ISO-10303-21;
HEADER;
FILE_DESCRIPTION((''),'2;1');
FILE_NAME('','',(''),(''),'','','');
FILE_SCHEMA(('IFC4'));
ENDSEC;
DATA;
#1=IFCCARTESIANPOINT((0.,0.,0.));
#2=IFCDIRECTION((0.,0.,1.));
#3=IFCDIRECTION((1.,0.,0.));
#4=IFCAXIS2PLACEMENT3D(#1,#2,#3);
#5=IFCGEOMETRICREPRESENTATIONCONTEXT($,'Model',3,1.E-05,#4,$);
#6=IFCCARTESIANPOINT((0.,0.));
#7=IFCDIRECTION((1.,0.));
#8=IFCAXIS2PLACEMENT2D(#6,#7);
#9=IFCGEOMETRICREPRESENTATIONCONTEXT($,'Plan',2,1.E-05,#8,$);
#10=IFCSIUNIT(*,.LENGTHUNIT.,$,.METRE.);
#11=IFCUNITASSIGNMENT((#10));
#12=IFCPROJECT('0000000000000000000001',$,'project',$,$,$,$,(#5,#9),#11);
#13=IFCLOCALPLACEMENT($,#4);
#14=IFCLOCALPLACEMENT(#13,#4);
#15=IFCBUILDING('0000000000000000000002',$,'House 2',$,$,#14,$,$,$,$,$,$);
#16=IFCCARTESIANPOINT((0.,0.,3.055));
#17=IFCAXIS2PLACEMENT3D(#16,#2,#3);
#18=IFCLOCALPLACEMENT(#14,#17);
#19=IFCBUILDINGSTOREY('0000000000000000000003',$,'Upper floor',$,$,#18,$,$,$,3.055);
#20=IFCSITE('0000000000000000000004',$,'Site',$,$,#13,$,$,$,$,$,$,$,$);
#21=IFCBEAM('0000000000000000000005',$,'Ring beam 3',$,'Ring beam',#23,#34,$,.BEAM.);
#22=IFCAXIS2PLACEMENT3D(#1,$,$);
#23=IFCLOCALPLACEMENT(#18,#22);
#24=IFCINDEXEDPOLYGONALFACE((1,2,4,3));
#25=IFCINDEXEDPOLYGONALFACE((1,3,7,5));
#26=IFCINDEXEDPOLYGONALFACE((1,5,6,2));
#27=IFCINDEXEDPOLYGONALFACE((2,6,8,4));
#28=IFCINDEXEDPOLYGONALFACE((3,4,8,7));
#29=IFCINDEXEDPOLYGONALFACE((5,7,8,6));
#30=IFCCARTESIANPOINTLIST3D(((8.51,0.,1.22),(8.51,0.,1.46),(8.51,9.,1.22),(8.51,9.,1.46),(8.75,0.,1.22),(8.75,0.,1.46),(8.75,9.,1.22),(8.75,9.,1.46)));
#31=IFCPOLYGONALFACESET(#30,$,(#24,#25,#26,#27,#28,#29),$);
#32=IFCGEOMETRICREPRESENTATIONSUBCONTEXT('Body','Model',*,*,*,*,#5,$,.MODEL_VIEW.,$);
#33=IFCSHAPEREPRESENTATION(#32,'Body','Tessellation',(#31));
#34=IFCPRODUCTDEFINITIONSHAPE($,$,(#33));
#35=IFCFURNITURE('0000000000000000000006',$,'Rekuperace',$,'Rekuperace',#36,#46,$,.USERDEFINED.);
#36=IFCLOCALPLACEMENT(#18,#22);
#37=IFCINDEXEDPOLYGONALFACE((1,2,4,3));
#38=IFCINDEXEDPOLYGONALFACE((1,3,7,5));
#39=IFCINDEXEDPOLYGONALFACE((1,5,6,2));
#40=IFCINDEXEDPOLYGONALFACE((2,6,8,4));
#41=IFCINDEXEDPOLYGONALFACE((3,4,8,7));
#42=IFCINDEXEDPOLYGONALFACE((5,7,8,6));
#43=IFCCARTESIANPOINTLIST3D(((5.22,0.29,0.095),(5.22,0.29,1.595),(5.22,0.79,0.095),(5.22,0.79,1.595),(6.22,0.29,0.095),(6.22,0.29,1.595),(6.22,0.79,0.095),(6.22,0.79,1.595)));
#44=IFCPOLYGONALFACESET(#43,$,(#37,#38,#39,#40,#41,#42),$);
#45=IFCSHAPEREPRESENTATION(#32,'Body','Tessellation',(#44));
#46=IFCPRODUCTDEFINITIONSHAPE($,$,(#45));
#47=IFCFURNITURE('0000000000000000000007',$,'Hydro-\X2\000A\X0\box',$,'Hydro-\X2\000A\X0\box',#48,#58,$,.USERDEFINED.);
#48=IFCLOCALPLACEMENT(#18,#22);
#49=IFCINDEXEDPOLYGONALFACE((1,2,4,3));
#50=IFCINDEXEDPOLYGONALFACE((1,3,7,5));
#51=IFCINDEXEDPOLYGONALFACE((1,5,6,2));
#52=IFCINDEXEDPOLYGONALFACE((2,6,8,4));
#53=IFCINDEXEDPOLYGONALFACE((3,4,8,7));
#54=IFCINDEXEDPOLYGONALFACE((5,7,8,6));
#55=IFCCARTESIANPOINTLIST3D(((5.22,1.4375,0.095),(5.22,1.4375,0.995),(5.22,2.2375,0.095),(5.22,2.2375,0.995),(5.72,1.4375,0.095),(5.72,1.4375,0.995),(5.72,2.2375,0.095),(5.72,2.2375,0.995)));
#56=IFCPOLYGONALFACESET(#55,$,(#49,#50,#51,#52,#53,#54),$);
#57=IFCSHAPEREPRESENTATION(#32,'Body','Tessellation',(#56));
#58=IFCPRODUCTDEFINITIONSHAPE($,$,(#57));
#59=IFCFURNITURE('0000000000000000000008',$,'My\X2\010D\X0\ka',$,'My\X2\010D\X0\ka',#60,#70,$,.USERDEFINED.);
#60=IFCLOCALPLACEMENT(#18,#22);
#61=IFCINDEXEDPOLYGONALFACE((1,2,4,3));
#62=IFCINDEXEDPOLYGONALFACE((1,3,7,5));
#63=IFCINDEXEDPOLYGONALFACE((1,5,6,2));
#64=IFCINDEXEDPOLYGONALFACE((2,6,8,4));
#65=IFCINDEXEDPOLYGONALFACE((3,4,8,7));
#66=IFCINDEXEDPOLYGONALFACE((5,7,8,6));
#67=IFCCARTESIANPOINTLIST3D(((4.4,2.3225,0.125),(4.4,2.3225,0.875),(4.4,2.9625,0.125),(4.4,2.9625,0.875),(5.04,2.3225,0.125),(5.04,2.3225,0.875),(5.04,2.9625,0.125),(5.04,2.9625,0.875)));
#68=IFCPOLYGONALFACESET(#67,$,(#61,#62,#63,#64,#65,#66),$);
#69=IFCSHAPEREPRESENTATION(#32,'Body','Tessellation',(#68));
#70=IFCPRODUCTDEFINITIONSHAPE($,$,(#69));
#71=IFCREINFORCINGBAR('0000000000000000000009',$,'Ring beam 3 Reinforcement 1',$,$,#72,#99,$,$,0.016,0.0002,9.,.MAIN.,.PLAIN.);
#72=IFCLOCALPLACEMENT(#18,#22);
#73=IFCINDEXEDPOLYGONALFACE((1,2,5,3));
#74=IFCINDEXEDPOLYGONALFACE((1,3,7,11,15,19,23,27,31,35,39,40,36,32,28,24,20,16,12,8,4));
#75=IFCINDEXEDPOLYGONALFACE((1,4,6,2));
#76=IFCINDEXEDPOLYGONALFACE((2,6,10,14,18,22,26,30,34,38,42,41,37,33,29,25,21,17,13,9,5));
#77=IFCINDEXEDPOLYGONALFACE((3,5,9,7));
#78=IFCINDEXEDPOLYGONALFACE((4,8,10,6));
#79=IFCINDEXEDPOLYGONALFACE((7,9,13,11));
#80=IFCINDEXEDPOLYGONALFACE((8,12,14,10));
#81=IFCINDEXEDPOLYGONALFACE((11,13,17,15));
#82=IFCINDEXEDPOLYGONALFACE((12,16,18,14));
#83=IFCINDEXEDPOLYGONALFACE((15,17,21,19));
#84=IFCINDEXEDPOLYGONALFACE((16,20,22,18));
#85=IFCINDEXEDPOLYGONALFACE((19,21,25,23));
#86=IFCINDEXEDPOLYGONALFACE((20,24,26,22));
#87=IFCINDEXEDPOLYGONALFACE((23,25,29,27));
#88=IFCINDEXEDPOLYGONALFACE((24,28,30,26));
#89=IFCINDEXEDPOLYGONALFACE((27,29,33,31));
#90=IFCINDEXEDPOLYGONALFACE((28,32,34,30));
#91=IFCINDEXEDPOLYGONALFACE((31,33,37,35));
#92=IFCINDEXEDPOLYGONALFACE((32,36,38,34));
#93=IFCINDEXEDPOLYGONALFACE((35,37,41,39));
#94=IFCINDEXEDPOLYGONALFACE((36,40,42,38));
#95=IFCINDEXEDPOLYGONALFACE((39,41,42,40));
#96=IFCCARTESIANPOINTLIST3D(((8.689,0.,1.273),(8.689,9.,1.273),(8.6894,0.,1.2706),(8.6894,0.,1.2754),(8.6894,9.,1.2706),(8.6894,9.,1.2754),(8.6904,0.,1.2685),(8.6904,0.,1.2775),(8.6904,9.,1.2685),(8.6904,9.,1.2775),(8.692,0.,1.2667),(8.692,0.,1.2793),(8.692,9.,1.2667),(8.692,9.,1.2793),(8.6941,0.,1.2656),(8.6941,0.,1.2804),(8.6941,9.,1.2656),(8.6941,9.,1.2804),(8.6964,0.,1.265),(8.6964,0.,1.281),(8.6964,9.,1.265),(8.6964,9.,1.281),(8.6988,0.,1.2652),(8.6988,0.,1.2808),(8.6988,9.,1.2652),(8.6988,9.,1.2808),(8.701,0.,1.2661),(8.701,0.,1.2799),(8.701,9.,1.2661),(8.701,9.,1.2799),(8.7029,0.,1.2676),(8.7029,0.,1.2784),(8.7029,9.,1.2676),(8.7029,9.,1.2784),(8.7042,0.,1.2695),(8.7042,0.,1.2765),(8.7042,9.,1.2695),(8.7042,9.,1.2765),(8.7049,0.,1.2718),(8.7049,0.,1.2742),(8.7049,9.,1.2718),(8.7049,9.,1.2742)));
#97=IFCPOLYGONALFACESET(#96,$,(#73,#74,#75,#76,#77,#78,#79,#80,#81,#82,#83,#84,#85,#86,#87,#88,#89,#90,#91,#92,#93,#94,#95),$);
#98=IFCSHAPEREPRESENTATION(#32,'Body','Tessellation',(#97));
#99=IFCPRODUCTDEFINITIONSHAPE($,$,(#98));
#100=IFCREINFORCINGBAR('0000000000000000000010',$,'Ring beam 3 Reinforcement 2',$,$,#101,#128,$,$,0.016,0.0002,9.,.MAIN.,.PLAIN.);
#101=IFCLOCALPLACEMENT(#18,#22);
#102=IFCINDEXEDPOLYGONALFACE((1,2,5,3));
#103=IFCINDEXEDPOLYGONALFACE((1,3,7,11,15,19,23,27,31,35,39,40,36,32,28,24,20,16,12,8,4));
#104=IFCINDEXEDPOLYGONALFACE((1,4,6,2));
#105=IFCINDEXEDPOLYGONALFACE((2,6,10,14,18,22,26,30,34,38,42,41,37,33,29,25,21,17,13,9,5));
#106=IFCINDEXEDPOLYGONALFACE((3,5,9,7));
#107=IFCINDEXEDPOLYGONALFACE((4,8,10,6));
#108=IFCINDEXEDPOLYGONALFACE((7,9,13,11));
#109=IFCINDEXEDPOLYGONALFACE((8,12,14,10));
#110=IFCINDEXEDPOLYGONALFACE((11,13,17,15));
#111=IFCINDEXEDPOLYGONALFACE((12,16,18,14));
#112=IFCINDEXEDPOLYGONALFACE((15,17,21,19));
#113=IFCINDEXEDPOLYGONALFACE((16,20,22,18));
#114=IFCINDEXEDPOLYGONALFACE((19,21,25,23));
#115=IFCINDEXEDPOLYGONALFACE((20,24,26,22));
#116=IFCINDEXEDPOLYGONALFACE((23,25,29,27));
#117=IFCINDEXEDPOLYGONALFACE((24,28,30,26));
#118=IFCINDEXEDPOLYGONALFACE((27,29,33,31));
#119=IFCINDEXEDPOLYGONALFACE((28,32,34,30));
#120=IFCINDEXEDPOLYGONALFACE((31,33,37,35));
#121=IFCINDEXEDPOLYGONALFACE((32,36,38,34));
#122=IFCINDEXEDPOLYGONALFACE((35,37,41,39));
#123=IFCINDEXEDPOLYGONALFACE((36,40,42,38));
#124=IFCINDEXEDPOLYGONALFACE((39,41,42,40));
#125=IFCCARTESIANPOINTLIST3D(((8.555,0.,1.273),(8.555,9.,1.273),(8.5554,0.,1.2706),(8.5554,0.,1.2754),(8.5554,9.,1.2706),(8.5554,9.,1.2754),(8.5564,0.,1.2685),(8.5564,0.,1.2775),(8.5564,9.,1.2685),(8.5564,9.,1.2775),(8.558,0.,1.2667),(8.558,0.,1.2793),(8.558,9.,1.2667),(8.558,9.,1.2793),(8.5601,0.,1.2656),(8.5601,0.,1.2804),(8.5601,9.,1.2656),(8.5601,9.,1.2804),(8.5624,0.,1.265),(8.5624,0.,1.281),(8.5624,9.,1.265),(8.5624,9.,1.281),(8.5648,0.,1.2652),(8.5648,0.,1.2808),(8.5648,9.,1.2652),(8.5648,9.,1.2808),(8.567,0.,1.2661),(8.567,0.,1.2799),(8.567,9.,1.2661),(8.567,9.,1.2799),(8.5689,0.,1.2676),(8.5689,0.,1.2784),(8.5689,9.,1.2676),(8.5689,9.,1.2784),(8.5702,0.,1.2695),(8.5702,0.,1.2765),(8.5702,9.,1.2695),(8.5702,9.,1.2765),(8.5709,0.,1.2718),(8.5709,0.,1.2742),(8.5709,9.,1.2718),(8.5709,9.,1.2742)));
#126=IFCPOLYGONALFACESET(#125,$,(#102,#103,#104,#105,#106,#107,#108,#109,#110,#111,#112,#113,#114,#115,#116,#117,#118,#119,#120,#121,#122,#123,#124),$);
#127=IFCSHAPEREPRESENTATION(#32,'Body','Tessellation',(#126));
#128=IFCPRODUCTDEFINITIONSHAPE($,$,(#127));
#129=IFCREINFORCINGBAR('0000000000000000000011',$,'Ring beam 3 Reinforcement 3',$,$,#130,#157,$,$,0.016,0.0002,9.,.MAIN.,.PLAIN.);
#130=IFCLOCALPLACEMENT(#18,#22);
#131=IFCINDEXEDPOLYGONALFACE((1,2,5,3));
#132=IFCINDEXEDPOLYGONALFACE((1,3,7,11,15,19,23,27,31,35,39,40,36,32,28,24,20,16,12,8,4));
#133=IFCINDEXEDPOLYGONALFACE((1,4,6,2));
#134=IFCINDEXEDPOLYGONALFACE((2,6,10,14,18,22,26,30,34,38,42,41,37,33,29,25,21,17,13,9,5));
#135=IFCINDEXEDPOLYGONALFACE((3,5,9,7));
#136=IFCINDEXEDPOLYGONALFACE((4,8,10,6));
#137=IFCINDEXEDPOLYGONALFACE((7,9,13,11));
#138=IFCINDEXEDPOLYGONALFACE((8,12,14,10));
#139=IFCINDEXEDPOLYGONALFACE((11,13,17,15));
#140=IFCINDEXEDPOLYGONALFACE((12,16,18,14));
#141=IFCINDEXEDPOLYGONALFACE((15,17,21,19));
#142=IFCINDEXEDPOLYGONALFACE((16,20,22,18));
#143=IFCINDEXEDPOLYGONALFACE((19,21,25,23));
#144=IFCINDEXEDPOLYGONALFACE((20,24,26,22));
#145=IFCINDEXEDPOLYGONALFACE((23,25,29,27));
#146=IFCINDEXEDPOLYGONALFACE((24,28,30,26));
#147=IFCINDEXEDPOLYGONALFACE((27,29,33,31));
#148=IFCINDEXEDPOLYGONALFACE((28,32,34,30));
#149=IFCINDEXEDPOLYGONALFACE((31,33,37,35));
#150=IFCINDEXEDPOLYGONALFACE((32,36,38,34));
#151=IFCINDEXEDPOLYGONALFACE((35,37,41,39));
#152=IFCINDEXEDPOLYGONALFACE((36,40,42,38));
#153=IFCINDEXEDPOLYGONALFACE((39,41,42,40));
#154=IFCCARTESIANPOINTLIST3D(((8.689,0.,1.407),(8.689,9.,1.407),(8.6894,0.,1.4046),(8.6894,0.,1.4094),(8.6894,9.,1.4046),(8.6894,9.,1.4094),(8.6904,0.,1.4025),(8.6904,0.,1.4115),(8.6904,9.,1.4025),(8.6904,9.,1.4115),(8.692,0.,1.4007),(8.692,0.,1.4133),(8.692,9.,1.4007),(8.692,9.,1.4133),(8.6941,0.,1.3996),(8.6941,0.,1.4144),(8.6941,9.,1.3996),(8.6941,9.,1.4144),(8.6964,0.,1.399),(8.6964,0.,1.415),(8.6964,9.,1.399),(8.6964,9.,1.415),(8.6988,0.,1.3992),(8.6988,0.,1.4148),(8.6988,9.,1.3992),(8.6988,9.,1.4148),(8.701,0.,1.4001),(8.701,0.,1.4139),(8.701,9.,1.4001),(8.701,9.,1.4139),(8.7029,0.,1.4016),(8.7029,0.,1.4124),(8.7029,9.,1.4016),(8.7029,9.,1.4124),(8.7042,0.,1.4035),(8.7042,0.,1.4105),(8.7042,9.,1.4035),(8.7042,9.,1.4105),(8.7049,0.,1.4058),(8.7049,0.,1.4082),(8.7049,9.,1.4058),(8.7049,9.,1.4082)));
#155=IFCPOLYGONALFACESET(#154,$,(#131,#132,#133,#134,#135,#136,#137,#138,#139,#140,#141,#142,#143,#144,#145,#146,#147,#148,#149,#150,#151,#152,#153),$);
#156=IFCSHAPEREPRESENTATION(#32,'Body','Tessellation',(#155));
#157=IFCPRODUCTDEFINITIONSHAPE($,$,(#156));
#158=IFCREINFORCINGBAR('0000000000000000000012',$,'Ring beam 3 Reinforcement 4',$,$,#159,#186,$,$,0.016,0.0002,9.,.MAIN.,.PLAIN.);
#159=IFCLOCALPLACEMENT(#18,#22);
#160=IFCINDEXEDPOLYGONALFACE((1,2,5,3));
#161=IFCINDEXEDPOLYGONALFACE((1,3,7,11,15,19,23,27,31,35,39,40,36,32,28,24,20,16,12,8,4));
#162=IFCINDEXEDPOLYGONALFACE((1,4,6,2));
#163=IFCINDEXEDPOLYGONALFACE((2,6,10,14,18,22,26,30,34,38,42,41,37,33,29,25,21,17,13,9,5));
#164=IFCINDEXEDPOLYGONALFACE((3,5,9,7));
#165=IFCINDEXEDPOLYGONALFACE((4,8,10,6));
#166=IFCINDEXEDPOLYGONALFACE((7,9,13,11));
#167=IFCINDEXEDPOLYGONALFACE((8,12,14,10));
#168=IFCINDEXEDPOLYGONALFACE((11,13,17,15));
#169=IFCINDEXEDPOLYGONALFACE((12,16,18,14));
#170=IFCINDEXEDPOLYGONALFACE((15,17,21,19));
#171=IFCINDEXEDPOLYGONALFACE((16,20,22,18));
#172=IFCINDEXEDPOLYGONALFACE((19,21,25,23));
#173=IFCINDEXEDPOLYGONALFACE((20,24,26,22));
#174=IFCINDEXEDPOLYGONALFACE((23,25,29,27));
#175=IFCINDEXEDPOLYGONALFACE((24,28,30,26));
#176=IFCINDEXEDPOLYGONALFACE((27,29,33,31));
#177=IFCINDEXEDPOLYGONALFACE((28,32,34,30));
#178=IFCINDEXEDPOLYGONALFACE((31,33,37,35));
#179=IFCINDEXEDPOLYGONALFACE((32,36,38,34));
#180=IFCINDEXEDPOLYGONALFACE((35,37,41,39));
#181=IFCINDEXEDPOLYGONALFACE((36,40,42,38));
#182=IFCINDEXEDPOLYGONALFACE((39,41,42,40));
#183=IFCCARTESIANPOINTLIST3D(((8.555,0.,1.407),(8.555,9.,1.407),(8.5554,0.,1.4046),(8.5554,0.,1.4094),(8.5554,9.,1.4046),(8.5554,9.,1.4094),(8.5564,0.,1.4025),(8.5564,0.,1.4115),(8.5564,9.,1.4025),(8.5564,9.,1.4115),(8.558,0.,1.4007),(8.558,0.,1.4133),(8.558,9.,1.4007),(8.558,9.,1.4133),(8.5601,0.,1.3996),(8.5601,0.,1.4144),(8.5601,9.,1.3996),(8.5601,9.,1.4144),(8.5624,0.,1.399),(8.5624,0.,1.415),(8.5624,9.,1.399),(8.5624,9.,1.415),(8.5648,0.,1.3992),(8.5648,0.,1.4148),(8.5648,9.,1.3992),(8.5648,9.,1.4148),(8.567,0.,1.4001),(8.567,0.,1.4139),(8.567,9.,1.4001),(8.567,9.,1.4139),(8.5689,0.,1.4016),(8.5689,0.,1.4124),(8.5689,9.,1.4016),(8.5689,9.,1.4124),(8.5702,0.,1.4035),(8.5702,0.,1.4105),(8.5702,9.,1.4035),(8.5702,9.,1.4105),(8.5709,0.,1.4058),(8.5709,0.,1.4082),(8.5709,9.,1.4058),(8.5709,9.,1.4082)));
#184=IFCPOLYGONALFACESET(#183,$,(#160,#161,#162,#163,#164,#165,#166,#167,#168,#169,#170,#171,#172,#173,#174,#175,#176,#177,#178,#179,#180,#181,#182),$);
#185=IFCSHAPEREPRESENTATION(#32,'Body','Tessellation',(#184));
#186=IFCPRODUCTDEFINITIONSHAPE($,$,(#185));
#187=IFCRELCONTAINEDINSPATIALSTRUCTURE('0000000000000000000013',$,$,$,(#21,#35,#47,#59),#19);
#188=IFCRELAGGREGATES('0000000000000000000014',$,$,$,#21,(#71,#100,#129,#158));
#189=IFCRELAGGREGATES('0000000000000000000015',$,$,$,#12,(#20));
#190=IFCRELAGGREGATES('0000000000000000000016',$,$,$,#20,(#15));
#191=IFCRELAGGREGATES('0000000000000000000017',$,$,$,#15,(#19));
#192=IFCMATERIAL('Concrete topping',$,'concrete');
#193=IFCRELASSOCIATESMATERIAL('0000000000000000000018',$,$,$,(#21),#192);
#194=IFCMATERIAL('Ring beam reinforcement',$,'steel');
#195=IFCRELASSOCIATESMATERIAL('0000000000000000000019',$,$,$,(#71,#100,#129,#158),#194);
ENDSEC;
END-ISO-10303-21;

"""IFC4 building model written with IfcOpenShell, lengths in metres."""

from ifc_helpers import new_model, entity, si_unit, frame, origin_with_axes, origin_2d, origin_2d_with_axis, place, context, subcontext, project, spatial, indexed_curve, circle_curve, rectangle, outline, extrude, shape, material, element, aggregate, save


model = new_model("IFC4")

# Units and contexts
model_context = context("Model", 3, precision=1e-05, world=origin_with_axes())
plan_context = context("Plan", 2, precision=1e-05, world=origin_2d_with_axis())
body_context_1 = subcontext(model_context, "Body", "Model", "MODEL_VIEW")
body_context_2 = subcontext(plan_context, "Body", "Plan", "PLAN_VIEW")
ifc_project = project(units=[si_unit("LENGTHUNIT", "METRE")], contexts=[model_context, plan_context])

# Site, building, storey
site_placement = place(None, origin_with_axes())
site = spatial("IfcSite", under=ifc_project, at=site_placement, Name="Site")
building_placement = place(site_placement, origin_with_axes())
building = spatial("IfcBuilding", under=site, at=building_placement, Name="House 2")
storey_placement = place(building_placement, frame((0.0, 0.0, 3.055), z_axis=(0.0, 0.0, 1.0), x_axis=(1.0, 0.0, 0.0)))
storey = spatial("IfcBuildingStorey", under=building, at=storey_placement, Name="Upper floor", Elevation=3.055)

# Beam
ifc_material_1 = material(Name="Concrete topping", Category="concrete")
beam_1_placement = place(storey_placement, frame((8.63, 0.0, 1.34), z_axis=(0.0, 0.0, 1.0), x_axis=(0.0, 1.0, 0.0)))
beam_1 = element("IfcBeam", 1, at=beam_1_placement, inside=storey, material=ifc_material_1, Name="Ring beam 3", ObjectType="Ring beam", PredefinedType="BEAM", context=body_context_1, shape_type="SweptSolid", body=[
    extrude(rectangle(XDim=0.24, YDim=0.24), frame((0.0, 0.0, 0.0), z_axis=(1.0, 0.0, 0.0), x_axis=(0.0, 1.0, 0.0)), (0.0, 0.0, 1.0), 9.0),
])

# Furniture
furniture_1_placement = place(storey_placement, frame((5.72, 0.54, 0.095), z_axis=(0.0, 0.0, 1.0), x_axis=(1.0, 0.0, 0.0)))
element("IfcFurniture", 2, at=furniture_1_placement, inside=storey, Name="Rekuperace", ObjectType="Rekuperace", PredefinedType="USERDEFINED", shapes=[
    shape(body_context_1, "Body", "SweptSolid", [extrude(outline(indexed_curve([(-0.5, -0.25), (0.5, -0.25), (0.5, 0.25), (-0.5, 0.25)])), None, (0.0, 0.0, 1.0), 1.5)]),
    shape(body_context_2, "Body", "Curve2D", [entity("IfcIndexedPolyCurve", entity("IfcCartesianPointList2D", [[-0.5, -0.25], [0.5, -0.25], [0.5, 0.25], [-0.5, 0.25], [-0.5, -0.25]]), None, False)]),
])
furniture_2_placement = place(storey_placement, frame((5.47, 1.8375, 0.095), z_axis=(0.0, 0.0, 1.0), x_axis=(0.0, 1.0, 0.0)))
element("IfcFurniture", 3, at=furniture_2_placement, inside=storey, Name="Hydro-\nbox", ObjectType="Hydro-\nbox", PredefinedType="USERDEFINED", shapes=[
    shape(body_context_1, "Body", "SweptSolid", [extrude(outline(indexed_curve([(-0.4, -0.25), (0.4, -0.25), (0.4, 0.25), (-0.4, 0.25)])), None, (0.0, 0.0, 1.0), 0.9)]),
    shape(body_context_2, "Body", "Curve2D", [entity("IfcIndexedPolyCurve", entity("IfcCartesianPointList2D", [[-0.4, -0.25], [0.4, -0.25], [0.4, 0.25], [-0.4, 0.25], [-0.4, -0.25]]), None, False)]),
])
furniture_3_placement = place(storey_placement, frame((4.72, 2.6425, 0.125), z_axis=(0.0, 0.0, 1.0), x_axis=(1.0, 0.0, 0.0)))
element("IfcFurniture", 4, at=furniture_3_placement, inside=storey, Name="Myčka", ObjectType="Myčka", PredefinedType="USERDEFINED", shapes=[
    shape(body_context_1, "Body", "SweptSolid", [extrude(outline(indexed_curve([(-0.32, -0.32), (0.32, -0.32), (0.32, 0.32), (-0.32, 0.32)])), None, (0.0, 0.0, 1.0), 0.75)]),
    shape(body_context_2, "Body", "Curve2D", [entity("IfcIndexedPolyCurve", entity("IfcCartesianPointList2D", [[-0.32, -0.32], [0.32, -0.32], [0.32, 0.32], [-0.32, 0.32], [-0.32, -0.32]]), None, False)]),
])

# Reinforcing bars
ifc_material_2 = material(Name="Ring beam reinforcement", Category="steel")
reinforcing_bar_1_placement = place(beam_1_placement, frame((0.0, -0.067, -0.067), z_axis=(0.0, 0.0, 1.0), x_axis=(1.0, 0.0, 0.0)))
reinforcing_bar_1 = element("IfcReinforcingBar", 5, at=reinforcing_bar_1_placement, material=ifc_material_2, Name="Ring beam 3 Reinforcement 1", BarLength=9.0, BarSurface="PLAIN", CrossSectionArea=0.0002, NominalDiameter=0.016, PredefinedType="MAIN", context=body_context_1, shape_type="SweptSolid", body=[
    extrude(outline(circle_curve(origin_2d(), 0.008)), frame((0.0, 0.0, 0.0), z_axis=(1.0, 0.0, 0.0), x_axis=(0.0, 1.0, 0.0)), (0.0, 0.0, 1.0), 9.0),
])
reinforcing_bar_2_placement = place(beam_1_placement, frame((0.0, 0.067, -0.067), z_axis=(0.0, 0.0, 1.0), x_axis=(1.0, 0.0, 0.0)))
reinforcing_bar_2 = element("IfcReinforcingBar", 6, at=reinforcing_bar_2_placement, material=ifc_material_2, Name="Ring beam 3 Reinforcement 2", BarLength=9.0, BarSurface="PLAIN", CrossSectionArea=0.0002, NominalDiameter=0.016, PredefinedType="MAIN", context=body_context_1, shape_type="SweptSolid", body=[
    extrude(outline(circle_curve(origin_2d(), 0.008)), frame((0.0, 0.0, 0.0), z_axis=(1.0, 0.0, 0.0), x_axis=(0.0, 1.0, 0.0)), (0.0, 0.0, 1.0), 9.0),
])
reinforcing_bar_3_placement = place(beam_1_placement, frame((0.0, -0.067, 0.067), z_axis=(0.0, 0.0, 1.0), x_axis=(1.0, 0.0, 0.0)))
reinforcing_bar_3 = element("IfcReinforcingBar", 7, at=reinforcing_bar_3_placement, material=ifc_material_2, Name="Ring beam 3 Reinforcement 3", BarLength=9.0, BarSurface="PLAIN", CrossSectionArea=0.0002, NominalDiameter=0.016, PredefinedType="MAIN", context=body_context_1, shape_type="SweptSolid", body=[
    extrude(outline(circle_curve(origin_2d(), 0.008)), frame((0.0, 0.0, 0.0), z_axis=(1.0, 0.0, 0.0), x_axis=(0.0, 1.0, 0.0)), (0.0, 0.0, 1.0), 9.0),
])
reinforcing_bar_4_placement = place(beam_1_placement, frame((0.0, 0.067, 0.067), z_axis=(0.0, 0.0, 1.0), x_axis=(1.0, 0.0, 0.0)))
reinforcing_bar_4 = element("IfcReinforcingBar", 8, at=reinforcing_bar_4_placement, material=ifc_material_2, Name="Ring beam 3 Reinforcement 4", BarLength=9.0, BarSurface="PLAIN", CrossSectionArea=0.0002, NominalDiameter=0.016, PredefinedType="MAIN", context=body_context_1, shape_type="SweptSolid", body=[
    extrude(outline(circle_curve(origin_2d(), 0.008)), frame((0.0, 0.0, 0.0), z_axis=(1.0, 0.0, 0.0), x_axis=(0.0, 1.0, 0.0)), (0.0, 0.0, 1.0), 9.0),
])
aggregate(beam_1, [reinforcing_bar_1, reinforcing_bar_2, reinforcing_bar_3, reinforcing_bar_4])

save(model, "model.ifc")
